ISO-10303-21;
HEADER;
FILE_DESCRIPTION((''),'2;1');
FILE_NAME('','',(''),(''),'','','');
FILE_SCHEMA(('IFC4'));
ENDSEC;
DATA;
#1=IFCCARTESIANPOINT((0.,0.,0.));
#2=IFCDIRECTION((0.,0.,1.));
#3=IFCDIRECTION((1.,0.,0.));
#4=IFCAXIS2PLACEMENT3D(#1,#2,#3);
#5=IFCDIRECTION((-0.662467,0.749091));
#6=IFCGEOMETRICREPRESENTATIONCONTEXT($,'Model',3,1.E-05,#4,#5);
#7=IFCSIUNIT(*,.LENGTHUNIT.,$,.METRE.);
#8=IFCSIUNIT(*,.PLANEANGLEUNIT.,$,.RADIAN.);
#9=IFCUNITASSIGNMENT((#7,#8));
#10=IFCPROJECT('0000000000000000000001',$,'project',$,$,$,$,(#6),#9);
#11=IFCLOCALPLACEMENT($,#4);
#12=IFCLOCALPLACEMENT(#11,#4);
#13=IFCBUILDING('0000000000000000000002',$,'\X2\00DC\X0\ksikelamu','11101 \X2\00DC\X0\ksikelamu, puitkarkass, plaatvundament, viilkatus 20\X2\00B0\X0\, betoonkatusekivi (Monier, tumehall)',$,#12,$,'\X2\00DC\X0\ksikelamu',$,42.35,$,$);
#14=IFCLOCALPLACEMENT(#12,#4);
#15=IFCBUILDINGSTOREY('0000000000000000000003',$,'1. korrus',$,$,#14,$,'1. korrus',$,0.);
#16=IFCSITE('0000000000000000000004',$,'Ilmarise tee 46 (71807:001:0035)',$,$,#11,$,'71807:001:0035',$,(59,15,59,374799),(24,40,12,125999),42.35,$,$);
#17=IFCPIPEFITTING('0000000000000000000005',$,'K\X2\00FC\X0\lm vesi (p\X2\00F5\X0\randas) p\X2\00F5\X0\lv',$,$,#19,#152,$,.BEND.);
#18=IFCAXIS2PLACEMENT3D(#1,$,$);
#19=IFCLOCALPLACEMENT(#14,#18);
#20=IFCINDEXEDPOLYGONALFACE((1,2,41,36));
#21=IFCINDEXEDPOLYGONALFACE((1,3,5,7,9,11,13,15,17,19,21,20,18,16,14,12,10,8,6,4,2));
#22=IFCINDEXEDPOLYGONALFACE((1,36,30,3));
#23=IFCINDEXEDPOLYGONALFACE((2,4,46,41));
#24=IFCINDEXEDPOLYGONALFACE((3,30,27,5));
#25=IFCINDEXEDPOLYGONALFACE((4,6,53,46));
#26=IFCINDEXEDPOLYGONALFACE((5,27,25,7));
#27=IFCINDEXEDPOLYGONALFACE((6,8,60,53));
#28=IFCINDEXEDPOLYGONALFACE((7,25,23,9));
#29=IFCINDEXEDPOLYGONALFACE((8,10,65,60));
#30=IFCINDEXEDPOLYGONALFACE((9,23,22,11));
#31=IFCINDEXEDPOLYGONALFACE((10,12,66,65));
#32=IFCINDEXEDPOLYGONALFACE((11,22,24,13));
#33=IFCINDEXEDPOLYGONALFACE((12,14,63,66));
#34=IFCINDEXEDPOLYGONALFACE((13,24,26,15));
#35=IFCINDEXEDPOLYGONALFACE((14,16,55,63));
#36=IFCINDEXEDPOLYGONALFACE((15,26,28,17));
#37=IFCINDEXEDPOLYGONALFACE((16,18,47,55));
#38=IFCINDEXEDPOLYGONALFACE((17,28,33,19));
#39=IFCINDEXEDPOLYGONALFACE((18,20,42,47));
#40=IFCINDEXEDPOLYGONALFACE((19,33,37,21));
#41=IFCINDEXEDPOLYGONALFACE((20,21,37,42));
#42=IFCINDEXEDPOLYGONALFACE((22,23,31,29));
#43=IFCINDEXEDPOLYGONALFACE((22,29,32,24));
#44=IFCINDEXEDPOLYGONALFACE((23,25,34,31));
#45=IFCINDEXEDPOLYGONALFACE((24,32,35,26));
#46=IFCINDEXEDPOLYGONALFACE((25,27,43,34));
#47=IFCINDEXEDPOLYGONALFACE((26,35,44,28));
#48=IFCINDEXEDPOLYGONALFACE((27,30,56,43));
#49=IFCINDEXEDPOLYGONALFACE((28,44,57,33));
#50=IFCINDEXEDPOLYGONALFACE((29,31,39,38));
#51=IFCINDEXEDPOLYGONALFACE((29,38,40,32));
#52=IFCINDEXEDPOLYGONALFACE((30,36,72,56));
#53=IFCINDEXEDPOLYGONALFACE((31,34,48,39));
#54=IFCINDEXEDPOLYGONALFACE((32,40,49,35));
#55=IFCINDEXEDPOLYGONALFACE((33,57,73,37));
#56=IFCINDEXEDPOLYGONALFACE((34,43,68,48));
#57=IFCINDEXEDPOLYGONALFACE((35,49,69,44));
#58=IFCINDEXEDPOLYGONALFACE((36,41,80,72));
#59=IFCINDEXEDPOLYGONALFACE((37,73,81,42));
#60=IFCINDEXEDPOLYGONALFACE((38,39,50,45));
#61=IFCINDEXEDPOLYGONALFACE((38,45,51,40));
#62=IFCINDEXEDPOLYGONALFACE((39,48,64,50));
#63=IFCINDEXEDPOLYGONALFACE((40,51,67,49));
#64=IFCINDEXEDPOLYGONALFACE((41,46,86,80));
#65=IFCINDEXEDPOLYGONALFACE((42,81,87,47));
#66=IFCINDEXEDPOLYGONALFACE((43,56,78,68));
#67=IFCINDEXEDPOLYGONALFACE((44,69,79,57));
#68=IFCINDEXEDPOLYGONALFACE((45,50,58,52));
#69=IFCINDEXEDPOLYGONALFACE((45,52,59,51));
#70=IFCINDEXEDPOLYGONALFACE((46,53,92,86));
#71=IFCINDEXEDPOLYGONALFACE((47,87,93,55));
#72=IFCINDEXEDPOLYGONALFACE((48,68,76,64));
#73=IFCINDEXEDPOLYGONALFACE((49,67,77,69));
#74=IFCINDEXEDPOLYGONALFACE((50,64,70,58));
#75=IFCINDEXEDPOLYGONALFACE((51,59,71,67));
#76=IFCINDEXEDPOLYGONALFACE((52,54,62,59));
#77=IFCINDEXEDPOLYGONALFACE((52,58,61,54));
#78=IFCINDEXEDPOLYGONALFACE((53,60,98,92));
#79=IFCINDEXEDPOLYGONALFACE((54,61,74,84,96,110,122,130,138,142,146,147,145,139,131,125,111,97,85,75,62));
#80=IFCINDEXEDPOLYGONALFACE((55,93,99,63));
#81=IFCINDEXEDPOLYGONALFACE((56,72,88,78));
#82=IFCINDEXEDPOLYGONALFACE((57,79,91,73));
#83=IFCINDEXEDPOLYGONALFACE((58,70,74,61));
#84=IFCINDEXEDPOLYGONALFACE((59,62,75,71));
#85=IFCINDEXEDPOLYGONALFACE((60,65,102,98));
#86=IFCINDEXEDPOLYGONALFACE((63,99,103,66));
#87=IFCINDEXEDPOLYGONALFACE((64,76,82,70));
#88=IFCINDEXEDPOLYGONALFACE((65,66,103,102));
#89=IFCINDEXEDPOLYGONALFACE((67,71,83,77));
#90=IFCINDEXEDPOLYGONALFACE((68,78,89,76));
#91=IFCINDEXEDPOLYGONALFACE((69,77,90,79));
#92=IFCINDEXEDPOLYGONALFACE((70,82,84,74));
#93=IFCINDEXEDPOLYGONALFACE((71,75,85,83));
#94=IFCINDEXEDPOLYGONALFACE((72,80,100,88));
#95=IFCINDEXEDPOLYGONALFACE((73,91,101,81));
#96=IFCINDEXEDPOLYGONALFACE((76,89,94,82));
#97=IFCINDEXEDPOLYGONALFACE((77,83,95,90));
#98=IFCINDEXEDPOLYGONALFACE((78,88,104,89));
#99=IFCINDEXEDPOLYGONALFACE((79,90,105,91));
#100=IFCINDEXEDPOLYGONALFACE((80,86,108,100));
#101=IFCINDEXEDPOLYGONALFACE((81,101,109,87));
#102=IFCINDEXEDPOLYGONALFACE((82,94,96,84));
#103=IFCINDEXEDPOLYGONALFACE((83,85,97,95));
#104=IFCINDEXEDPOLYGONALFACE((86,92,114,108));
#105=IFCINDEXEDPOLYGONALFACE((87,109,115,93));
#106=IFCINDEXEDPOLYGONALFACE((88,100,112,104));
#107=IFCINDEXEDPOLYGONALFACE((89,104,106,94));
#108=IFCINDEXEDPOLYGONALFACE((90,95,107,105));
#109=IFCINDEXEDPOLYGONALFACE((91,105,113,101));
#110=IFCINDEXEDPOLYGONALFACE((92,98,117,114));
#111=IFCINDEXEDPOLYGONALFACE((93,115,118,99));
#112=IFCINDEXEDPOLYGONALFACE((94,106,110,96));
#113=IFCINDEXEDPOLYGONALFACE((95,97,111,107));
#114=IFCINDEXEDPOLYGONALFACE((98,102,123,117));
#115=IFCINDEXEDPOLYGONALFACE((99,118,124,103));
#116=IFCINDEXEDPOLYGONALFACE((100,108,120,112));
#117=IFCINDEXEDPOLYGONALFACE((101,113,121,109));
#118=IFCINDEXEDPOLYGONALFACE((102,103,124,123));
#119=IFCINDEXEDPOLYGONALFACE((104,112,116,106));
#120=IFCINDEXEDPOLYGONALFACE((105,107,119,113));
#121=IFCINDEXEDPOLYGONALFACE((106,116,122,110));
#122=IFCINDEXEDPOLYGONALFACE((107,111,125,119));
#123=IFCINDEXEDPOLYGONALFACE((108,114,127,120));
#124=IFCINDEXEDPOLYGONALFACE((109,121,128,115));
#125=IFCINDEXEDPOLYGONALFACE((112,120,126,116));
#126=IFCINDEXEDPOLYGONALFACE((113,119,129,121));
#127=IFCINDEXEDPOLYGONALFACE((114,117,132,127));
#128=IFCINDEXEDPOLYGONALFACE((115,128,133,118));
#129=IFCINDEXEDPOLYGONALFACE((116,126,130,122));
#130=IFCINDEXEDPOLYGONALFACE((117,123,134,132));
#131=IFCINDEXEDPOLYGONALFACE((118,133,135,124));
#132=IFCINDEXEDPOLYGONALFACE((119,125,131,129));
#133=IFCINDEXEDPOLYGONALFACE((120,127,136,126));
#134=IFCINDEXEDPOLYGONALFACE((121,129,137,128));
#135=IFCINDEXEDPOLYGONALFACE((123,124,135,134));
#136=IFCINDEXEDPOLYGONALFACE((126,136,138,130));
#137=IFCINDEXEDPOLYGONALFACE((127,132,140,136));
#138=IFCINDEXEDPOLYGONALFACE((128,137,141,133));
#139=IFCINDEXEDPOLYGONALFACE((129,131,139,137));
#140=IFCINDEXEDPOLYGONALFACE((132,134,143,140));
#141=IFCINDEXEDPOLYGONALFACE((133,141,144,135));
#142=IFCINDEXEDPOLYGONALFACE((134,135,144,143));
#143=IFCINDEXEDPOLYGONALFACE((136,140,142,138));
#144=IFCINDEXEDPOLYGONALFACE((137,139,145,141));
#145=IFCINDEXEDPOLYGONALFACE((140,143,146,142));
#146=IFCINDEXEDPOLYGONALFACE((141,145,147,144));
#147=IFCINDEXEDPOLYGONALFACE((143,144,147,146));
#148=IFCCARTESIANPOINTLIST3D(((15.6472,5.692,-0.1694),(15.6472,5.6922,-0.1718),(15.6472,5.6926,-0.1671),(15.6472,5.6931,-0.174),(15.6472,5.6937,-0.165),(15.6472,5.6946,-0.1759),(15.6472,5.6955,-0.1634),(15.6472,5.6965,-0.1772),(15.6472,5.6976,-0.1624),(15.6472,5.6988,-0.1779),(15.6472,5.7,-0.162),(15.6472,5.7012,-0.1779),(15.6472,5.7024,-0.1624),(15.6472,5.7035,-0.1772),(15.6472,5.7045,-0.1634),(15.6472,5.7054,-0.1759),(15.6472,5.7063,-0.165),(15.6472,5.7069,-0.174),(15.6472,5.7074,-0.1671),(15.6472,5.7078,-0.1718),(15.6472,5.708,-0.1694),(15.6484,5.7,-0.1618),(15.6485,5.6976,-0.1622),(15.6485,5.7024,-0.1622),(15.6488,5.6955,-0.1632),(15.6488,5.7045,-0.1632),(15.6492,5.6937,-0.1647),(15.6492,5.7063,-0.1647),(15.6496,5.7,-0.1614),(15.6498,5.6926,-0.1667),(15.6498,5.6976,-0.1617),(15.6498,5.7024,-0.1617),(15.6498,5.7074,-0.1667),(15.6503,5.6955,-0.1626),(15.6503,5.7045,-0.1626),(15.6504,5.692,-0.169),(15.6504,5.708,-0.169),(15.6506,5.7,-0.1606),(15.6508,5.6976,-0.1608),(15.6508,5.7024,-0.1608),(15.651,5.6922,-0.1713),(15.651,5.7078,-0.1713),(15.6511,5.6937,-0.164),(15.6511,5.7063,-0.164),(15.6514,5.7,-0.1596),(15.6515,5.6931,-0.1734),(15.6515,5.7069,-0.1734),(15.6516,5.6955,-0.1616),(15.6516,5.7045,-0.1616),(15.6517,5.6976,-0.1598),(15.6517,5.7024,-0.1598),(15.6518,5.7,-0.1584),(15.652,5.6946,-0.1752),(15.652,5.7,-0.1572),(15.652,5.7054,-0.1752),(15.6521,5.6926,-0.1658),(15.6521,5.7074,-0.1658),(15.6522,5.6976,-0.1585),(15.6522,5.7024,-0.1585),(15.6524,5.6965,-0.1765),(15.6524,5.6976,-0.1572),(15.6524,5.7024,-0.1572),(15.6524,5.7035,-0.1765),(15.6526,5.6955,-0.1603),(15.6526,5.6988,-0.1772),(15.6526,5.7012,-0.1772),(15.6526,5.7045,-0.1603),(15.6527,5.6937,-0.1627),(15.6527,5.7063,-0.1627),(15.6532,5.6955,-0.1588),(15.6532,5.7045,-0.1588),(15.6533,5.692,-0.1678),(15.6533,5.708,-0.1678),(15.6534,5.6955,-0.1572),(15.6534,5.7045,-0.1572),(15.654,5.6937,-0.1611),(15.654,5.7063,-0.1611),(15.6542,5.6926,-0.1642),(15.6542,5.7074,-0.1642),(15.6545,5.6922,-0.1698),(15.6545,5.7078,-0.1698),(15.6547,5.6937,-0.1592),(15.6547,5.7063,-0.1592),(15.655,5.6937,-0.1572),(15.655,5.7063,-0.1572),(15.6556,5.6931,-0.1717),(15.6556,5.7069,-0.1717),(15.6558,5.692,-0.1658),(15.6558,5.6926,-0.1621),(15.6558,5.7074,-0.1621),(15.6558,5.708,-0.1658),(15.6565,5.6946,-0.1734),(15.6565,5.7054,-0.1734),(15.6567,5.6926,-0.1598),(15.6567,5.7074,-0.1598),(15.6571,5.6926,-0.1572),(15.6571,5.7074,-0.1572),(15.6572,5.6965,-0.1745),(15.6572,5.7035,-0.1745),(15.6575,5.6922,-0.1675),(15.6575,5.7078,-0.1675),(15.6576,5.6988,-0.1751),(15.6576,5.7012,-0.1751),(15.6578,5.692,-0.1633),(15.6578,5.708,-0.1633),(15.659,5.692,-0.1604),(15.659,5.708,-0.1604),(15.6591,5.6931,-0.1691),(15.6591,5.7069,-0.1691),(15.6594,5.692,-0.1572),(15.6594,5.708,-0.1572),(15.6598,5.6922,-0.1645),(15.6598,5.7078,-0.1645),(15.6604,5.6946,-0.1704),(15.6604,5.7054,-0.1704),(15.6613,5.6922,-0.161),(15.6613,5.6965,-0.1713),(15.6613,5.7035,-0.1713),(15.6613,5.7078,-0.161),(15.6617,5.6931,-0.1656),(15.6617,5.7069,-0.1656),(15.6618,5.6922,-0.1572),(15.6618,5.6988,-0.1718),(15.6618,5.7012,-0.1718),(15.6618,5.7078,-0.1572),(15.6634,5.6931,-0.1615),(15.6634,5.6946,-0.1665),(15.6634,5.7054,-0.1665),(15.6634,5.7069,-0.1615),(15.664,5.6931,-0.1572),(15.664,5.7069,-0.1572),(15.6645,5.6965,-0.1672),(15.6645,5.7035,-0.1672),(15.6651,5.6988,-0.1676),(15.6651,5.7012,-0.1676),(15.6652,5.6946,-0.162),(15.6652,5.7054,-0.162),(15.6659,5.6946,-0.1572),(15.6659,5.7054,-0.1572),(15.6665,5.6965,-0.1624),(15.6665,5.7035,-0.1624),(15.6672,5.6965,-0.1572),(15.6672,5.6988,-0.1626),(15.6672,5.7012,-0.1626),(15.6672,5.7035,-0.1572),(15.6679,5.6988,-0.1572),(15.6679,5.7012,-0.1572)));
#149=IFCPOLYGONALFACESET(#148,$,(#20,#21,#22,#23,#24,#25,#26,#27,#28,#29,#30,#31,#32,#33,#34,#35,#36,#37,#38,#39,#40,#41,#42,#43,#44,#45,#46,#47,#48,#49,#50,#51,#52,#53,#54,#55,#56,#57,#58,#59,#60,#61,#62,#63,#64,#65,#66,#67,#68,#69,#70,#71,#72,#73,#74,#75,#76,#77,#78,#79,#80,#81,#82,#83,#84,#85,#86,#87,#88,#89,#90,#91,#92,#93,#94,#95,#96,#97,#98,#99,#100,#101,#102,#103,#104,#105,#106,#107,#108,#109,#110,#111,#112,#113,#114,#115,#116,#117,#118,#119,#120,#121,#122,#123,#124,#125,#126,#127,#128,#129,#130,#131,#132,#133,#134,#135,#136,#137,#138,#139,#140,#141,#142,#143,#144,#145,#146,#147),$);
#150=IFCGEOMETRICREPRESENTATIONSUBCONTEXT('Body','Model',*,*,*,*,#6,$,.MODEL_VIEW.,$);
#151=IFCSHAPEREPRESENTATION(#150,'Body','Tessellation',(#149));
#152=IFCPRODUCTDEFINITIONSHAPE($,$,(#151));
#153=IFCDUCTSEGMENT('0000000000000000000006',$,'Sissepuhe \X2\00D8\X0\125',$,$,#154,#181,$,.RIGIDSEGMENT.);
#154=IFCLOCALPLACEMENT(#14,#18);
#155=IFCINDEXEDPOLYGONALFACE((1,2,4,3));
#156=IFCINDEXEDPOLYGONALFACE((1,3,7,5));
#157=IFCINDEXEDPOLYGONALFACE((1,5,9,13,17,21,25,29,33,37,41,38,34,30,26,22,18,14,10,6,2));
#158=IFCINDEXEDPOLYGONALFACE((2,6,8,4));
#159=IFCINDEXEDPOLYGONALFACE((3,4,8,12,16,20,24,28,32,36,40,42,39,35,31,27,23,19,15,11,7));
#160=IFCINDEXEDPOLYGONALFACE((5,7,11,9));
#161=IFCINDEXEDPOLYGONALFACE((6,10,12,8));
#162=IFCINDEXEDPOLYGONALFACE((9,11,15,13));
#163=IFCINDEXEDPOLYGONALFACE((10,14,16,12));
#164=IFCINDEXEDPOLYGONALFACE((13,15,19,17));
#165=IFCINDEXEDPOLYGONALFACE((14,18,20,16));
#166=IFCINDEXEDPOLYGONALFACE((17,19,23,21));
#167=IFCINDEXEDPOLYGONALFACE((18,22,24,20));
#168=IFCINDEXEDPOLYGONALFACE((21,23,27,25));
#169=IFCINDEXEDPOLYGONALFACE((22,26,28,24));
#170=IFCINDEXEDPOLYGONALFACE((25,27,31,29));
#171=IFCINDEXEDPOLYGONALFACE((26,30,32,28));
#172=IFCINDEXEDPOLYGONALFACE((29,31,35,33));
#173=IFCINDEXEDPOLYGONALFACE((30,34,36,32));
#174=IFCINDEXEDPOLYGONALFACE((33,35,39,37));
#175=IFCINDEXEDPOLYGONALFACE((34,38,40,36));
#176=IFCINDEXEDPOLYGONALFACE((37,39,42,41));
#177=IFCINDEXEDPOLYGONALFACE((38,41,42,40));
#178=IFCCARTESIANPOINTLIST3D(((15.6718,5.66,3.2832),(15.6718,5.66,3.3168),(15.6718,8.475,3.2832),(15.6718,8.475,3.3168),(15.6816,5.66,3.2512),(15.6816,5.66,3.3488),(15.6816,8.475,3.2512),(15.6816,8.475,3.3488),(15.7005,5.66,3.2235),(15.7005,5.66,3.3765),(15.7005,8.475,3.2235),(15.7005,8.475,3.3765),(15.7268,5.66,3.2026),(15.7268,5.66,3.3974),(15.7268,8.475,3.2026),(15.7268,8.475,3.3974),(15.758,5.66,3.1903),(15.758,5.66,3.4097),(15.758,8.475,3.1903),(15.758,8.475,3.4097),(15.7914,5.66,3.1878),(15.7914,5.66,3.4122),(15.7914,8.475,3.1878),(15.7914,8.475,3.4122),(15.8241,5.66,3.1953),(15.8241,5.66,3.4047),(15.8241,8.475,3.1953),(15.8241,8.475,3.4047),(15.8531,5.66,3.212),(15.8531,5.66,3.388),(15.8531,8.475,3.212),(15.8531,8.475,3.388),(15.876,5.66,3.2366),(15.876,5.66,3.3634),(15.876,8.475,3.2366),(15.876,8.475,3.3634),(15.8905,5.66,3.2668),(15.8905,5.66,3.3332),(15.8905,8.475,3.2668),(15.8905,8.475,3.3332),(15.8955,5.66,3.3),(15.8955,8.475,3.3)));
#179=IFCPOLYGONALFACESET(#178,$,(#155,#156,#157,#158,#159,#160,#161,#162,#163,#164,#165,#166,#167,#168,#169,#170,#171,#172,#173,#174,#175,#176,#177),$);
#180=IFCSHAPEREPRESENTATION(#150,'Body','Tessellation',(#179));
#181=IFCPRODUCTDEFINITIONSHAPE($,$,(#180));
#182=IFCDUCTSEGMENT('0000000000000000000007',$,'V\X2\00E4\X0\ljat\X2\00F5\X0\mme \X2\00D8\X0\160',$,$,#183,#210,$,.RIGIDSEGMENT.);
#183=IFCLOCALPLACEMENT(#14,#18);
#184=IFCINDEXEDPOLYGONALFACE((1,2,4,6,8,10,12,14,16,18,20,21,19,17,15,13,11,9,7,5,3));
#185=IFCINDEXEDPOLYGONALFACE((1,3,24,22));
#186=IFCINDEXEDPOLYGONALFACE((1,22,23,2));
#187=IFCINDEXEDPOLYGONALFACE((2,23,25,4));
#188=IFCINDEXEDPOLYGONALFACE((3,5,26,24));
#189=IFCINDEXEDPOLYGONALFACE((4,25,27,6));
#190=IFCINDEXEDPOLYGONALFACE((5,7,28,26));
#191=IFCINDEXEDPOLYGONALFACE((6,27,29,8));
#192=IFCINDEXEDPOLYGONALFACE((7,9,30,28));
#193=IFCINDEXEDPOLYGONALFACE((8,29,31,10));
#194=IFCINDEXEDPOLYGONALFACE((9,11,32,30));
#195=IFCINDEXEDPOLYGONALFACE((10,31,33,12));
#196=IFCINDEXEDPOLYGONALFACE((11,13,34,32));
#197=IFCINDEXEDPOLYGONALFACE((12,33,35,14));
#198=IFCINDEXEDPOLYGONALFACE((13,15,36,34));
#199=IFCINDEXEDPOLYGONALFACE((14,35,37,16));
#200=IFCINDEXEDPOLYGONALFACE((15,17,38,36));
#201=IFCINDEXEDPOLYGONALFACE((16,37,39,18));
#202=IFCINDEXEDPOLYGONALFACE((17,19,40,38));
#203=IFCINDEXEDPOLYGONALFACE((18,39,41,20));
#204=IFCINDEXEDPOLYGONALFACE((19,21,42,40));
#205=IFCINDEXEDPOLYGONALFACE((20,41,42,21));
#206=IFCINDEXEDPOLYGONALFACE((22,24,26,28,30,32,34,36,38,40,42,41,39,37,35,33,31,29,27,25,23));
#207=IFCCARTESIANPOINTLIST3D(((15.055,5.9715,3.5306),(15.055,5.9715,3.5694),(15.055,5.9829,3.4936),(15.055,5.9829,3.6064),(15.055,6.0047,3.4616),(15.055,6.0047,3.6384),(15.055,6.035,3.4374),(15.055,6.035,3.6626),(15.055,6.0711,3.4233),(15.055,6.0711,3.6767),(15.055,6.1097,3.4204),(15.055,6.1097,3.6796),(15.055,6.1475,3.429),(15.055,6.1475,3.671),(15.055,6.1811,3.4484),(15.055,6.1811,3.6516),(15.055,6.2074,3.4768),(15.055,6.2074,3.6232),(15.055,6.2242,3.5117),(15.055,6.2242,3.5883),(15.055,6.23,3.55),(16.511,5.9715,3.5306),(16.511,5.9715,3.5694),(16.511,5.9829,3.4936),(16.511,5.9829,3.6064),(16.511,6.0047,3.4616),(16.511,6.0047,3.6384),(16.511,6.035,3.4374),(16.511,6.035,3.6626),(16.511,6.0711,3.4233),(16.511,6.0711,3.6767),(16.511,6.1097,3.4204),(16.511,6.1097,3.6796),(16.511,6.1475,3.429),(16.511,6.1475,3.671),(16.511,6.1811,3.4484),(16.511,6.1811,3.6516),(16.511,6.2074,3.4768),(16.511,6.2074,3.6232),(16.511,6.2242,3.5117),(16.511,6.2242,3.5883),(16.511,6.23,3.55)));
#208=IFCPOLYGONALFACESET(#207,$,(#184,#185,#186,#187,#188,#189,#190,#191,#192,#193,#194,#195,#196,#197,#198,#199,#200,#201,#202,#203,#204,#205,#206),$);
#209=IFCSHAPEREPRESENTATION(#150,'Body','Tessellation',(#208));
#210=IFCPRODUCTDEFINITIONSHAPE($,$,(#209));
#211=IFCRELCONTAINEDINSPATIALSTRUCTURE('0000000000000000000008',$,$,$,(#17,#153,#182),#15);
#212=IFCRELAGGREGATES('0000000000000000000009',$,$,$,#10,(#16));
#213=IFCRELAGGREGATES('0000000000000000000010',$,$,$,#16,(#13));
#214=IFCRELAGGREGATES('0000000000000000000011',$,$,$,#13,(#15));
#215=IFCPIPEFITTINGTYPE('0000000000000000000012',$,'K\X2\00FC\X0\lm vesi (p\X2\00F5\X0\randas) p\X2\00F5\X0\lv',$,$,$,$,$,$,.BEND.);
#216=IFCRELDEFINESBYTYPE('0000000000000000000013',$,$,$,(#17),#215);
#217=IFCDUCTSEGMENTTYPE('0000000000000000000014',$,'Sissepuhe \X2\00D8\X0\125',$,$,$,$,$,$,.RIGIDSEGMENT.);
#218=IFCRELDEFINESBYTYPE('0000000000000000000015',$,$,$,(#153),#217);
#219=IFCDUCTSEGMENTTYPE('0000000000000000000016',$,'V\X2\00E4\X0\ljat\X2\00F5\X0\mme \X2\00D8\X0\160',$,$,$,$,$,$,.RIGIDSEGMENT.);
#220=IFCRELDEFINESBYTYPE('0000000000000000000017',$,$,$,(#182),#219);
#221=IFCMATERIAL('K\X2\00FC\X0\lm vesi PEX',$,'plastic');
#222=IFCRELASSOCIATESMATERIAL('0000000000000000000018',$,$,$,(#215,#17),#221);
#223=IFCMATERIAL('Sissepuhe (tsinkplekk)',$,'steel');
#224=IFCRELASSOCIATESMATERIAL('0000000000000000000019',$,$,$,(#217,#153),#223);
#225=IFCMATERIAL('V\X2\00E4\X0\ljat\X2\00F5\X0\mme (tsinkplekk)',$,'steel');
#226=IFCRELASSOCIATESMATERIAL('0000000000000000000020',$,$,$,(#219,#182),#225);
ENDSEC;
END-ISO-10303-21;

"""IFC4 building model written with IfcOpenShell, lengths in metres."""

from ifc_helpers import new_model, entity, si_unit, direction, frame, origin_with_axes, place, context, subcontext, project, spatial, circle, extrude, material, type_object, element, save


model = new_model("IFC4")

# Units and contexts
model_context = context("Model", 3, precision=1e-05, world=origin_with_axes(), true_north=direction((-0.662467, 0.749091)))
body_context = subcontext(model_context, "Body", "Model", "MODEL_VIEW")
ifc_project = project(units=[si_unit("LENGTHUNIT", "METRE"), si_unit("PLANEANGLEUNIT", "RADIAN")], contexts=[model_context])

# Site, building, storey
site_placement = place(None, origin_with_axes())
site = spatial("IfcSite", under=ifc_project, at=site_placement, Name="Ilmarise tee 46 (71807:001:0035)", LongName="71807:001:0035", RefLatitude=(59, 15, 59, 374799), RefLongitude=(24, 40, 12, 125999), RefElevation=42.35)
building_placement = place(site_placement, origin_with_axes())
building = spatial("IfcBuilding", under=site, at=building_placement, Name="Üksikelamu", Description="11101 Üksikelamu, puitkarkass, plaatvundament, viilkatus 20°, betoonkatusekivi (Monier, tumehall)", LongName="Üksikelamu", ElevationOfRefHeight=42.35)
storey_placement = place(building_placement, origin_with_axes())
storey = spatial("IfcBuildingStorey", under=building, at=storey_placement, Name="1. korrus", LongName="1. korrus", Elevation=0.0)

# Shared definitions
ifc_material_1 = material(Name="Sissepuhe (tsinkplekk)", Category="steel")
ifc_material_2 = material(Name="Väljatõmme (tsinkplekk)", Category="steel")

# Pipe fitting
ifc_material_3 = material(Name="Külm vesi PEX", Category="plastic")
pipe_fitting_type_1 = type_object("IfcPipeFittingType", Name="Külm vesi (põrandas) põlv", PredefinedType="BEND", material=ifc_material_3)
pipe_fitting_1_placement = place(storey_placement, frame((15.66, 5.7, -0.17), z_axis=(0.0, 0.0, 1.0), x_axis=(1.0, 0.0, 0.0)))
element("IfcPipeFitting", 1, at=pipe_fitting_1_placement, inside=storey, type_object=pipe_fitting_type_1, material=ifc_material_3, Name="Külm vesi (põrandas) põlv", PredefinedType="BEND", context=body_context, shape_type="SweptSolid", body=[
    entity("IfcRevolvedAreaSolid", entity("IfcCircleProfileDef", "AREA", None, None, 0.008), entity("IfcAxis2Placement3D", entity("IfcCartesianPoint", [-0.0128, 0.0, 0.0]), entity("IfcDirection", [1.0, 0.0, 0.0]), entity("IfcDirection", [0.0, 0.0, 1.0])), entity("IfcAxis1Placement", entity("IfcCartesianPoint", [0.0128, 0.0, 0.0]), entity("IfcDirection", [0.0, 1.0, 0.0])), 1.570796),
])

# Duct segments
duct_segment_type_1 = type_object("IfcDuctSegmentType", Name="Sissepuhe Ø125", PredefinedType="RIGIDSEGMENT", material=ifc_material_1)
duct_segment_1_placement = place(storey_placement, frame((15.783, 5.66, 3.3), z_axis=(0.0, 1.0, 0.0), x_axis=(1.0, 0.0, 0.0)))
element("IfcDuctSegment", 2, at=duct_segment_1_placement, inside=storey, type_object=duct_segment_type_1, material=ifc_material_1, Name="Sissepuhe Ø125", PredefinedType="RIGIDSEGMENT", context=body_context, shape_type="SweptSolid", body=[
    extrude(circle(Radius=0.1125), origin_with_axes(), (0.0, 0.0, 1.0), 2.815),
])
duct_segment_type_2 = type_object("IfcDuctSegmentType", Name="Väljatõmme Ø160", PredefinedType="RIGIDSEGMENT", material=ifc_material_2)
duct_segment_2_placement = place(storey_placement, frame((16.511, 6.1, 3.55), z_axis=(-1.0, 0.0, 0.0), x_axis=(0.0, 1.0, 0.0)))
element("IfcDuctSegment", 3, at=duct_segment_2_placement, inside=storey, type_object=duct_segment_type_2, material=ifc_material_2, Name="Väljatõmme Ø160", PredefinedType="RIGIDSEGMENT", context=body_context, shape_type="SweptSolid", body=[
    extrude(circle(Radius=0.13), origin_with_axes(), (0.0, 0.0, 1.0), 1.456),
])

save(model, "model.ifc")
